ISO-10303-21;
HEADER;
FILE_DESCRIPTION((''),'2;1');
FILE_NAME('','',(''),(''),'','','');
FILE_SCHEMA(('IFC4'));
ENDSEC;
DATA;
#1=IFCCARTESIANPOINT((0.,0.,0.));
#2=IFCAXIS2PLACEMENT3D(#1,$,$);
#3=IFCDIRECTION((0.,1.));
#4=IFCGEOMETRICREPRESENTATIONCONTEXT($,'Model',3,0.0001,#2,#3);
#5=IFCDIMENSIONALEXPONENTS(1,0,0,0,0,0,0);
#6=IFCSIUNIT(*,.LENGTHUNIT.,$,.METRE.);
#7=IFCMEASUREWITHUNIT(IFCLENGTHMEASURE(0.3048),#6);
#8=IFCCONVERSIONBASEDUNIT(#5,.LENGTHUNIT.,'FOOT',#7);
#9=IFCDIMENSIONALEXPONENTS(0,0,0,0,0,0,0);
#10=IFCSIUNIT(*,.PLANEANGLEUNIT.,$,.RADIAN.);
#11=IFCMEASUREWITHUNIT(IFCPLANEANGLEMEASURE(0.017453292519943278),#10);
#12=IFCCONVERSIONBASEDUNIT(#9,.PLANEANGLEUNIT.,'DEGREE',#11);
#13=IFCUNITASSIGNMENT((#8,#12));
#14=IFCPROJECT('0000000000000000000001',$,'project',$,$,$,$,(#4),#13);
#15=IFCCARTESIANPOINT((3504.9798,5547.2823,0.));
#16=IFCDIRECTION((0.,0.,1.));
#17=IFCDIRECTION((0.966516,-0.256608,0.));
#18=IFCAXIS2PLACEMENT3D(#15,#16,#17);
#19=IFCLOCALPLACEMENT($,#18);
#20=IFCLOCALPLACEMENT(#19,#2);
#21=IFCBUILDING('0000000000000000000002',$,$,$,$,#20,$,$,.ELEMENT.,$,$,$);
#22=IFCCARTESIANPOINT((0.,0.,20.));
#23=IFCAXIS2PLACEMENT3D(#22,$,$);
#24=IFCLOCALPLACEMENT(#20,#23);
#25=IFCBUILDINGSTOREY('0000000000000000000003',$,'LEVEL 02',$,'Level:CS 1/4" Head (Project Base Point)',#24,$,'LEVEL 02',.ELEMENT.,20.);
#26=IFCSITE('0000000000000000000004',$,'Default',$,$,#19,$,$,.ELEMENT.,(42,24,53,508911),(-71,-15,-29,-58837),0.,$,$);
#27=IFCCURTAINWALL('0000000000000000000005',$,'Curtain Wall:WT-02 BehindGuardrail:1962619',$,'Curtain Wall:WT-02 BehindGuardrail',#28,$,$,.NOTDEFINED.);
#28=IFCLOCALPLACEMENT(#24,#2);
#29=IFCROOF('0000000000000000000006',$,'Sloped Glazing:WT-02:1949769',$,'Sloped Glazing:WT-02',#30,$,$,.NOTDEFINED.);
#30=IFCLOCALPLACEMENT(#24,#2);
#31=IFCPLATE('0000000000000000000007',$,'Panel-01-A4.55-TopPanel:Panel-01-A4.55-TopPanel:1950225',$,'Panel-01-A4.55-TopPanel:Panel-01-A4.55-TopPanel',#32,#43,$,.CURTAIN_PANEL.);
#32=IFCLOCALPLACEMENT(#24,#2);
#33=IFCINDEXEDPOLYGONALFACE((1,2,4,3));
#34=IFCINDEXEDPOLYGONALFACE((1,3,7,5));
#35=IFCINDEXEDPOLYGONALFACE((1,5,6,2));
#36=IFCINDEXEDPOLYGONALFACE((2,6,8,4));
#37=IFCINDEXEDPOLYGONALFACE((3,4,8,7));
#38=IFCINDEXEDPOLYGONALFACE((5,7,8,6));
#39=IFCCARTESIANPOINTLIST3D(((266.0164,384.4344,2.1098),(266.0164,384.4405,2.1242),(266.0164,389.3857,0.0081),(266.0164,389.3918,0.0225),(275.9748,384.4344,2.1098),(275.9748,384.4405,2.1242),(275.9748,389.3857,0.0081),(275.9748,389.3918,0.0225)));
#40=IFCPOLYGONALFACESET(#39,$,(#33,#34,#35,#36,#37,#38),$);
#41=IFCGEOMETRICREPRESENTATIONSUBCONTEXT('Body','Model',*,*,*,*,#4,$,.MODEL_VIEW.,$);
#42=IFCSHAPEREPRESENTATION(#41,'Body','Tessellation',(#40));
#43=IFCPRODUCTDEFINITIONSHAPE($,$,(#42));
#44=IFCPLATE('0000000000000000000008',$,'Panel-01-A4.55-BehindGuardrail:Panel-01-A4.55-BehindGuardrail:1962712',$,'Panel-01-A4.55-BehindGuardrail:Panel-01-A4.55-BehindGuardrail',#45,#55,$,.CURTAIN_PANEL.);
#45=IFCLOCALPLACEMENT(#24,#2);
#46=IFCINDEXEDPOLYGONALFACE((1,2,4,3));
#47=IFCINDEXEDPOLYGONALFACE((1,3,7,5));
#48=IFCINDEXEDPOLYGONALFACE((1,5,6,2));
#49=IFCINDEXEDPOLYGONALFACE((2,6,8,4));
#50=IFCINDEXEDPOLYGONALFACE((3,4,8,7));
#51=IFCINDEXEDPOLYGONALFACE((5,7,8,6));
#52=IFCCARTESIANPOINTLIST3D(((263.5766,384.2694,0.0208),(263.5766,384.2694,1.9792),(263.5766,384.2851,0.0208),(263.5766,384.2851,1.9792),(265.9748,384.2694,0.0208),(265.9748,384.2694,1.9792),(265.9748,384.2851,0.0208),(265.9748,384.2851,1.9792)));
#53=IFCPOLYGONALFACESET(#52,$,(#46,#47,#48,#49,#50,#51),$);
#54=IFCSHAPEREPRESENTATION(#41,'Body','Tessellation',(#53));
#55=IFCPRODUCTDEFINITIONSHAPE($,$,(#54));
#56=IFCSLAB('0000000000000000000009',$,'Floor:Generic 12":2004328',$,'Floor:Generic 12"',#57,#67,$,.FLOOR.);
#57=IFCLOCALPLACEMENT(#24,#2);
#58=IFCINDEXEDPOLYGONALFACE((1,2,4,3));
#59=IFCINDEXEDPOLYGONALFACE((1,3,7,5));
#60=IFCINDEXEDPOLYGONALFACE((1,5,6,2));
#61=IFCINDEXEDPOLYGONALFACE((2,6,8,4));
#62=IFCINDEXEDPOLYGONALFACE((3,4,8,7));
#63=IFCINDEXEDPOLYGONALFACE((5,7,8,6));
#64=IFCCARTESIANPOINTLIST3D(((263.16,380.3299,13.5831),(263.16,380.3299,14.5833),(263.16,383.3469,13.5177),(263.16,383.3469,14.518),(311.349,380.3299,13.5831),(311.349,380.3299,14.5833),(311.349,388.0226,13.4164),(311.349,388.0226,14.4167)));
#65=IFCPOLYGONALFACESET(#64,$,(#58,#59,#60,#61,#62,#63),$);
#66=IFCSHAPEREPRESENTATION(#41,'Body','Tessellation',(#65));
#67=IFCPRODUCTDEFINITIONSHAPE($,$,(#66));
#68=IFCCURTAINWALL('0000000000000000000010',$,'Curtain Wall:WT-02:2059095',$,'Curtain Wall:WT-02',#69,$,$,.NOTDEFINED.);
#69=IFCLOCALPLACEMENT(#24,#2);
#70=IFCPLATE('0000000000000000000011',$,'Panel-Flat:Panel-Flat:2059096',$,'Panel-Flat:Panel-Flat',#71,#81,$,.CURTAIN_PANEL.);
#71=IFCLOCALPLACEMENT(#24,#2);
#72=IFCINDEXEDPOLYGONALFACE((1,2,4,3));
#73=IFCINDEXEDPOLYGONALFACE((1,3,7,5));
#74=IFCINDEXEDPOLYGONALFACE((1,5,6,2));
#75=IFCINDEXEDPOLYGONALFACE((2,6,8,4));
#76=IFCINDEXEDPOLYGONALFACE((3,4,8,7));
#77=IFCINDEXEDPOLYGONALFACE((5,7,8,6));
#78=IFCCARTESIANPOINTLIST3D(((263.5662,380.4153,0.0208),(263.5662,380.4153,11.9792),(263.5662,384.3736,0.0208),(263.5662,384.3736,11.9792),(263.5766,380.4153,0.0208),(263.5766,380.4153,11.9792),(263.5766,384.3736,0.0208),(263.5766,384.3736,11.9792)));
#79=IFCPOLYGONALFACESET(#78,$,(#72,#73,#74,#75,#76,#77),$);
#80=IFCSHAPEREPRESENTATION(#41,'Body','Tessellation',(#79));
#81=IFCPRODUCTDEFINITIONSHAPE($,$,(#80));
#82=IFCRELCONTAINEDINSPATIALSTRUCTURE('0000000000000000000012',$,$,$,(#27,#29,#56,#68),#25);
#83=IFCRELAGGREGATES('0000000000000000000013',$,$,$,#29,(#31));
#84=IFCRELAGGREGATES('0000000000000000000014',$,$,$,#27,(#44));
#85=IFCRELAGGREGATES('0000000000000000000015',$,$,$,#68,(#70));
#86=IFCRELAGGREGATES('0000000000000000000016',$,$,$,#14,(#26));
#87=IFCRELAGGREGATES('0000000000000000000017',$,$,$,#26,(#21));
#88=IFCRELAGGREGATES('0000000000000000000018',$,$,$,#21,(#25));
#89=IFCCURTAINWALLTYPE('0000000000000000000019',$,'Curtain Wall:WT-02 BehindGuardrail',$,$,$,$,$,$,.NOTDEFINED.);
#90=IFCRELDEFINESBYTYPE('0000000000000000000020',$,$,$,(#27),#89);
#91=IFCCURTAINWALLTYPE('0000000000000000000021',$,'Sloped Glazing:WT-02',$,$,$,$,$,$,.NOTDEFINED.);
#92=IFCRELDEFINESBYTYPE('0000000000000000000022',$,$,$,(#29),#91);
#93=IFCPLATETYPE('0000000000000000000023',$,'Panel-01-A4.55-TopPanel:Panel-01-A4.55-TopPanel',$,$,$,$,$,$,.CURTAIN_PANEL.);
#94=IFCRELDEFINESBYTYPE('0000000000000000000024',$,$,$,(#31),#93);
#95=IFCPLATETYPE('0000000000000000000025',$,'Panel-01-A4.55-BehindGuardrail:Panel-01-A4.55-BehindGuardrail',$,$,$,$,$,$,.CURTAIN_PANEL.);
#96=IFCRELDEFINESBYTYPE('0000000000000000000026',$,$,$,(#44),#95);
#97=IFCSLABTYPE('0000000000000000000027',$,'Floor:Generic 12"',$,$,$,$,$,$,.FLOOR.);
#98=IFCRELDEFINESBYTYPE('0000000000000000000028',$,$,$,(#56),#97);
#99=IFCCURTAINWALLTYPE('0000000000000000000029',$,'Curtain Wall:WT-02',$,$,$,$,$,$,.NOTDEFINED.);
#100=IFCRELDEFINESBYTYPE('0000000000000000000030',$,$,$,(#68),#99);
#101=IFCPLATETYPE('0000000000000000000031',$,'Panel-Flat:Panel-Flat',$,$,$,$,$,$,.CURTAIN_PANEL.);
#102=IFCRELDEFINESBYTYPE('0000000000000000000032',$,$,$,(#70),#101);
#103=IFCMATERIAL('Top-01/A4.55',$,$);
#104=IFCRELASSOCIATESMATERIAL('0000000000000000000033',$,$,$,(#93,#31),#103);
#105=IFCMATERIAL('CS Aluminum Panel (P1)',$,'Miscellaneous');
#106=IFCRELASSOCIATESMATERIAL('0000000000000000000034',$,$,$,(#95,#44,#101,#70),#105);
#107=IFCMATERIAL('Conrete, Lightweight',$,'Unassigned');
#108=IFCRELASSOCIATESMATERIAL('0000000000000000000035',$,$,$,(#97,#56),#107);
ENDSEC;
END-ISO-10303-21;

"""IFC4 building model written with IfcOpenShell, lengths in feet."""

from ifc_helpers import new_model, entity, si_unit, converted_unit, direction, frame, origin, place, context, subcontext, project, spatial, polyline, indexed_curve, outline, extrude, source, transform, mapped, material, type_object, type_shapes, element, aggregate, save


model = new_model("IFC4")

# Units and contexts
model_context = context("Model", 3, precision=0.0001, world=origin(), true_north=direction((0.0, 1.0)))
body_context = subcontext(model_context, "Body", "Model", "MODEL_VIEW")
ifc_project = project(units=[converted_unit("LENGTHUNIT", "FOOT", entity("IfcLengthMeasure", 0.3048), si_unit("LENGTHUNIT", "METRE"), dimensions=[1, 0, 0, 0, 0, 0, 0]), converted_unit("PLANEANGLEUNIT", "DEGREE", entity("IfcPlaneAngleMeasure", 0.017453292519943278), si_unit("PLANEANGLEUNIT", "RADIAN"), dimensions=[0, 0, 0, 0, 0, 0, 0])], contexts=[model_context])

# Site, building, storey
site_placement = place(None, frame((3504.9798, 5547.2823, 0.0), z_axis=(0.0, 0.0, 1.0), x_axis=(0.966516, -0.256608, 0.0)))
site = spatial("IfcSite", under=ifc_project, at=site_placement, Name="Default", CompositionType="ELEMENT", RefLatitude=(42, 24, 53, 508911), RefLongitude=(-71, -15, -29, -58837), RefElevation=0.0)
building_placement = place(site_placement, origin())
building = spatial("IfcBuilding", under=site, at=building_placement, CompositionType="ELEMENT")
storey_placement = place(building_placement, frame((0.0, 0.0, 20.0)))
storey = spatial("IfcBuildingStorey", under=building, at=storey_placement, Name="LEVEL 02", ObjectType="Level:CS 1/4\" Head (Project Base Point)", LongName="LEVEL 02", CompositionType="ELEMENT", Elevation=20.0)

# Curtain wall
curtain_wall_type_1 = type_object("IfcCurtainWallType", Name="Curtain Wall:WT-02", PredefinedType="NOTDEFINED")
ifc_material_1 = material(Name="CS Aluminum Panel (P1)", Category="Miscellaneous")
curtain_wall_type_2 = type_object("IfcCurtainWallType", Name="Curtain Wall:WT-02 BehindGuardrail", PredefinedType="NOTDEFINED")
curtain_wall_1_placement = place(storey_placement, frame((0.0, 0.0, -20.0)))
curtain_wall_1 = element("IfcCurtainWall", 1, at=curtain_wall_1_placement, inside=storey, type_object=curtain_wall_type_2, Name="Curtain Wall:WT-02 BehindGuardrail:1962619", ObjectType="Curtain Wall:WT-02 BehindGuardrail", PredefinedType="NOTDEFINED")

# Roof, plate
curtain_wall_type_3 = type_object("IfcCurtainWallType", Name="Sloped Glazing:WT-02", PredefinedType="NOTDEFINED")
roof_1_placement = place(storey_placement, frame((0.0, 0.0, -20.0)))
roof_1 = element("IfcRoof", 2, at=roof_1_placement, inside=storey, type_object=curtain_wall_type_3, Name="Sloped Glazing:WT-02:1949769", ObjectType="Sloped Glazing:WT-02", PredefinedType="NOTDEFINED")
ifc_material_2 = material(Name="Top-01/A4.55")
plate_type_1 = type_object("IfcPlateType", Name="Panel-01-A4.55-TopPanel:Panel-01-A4.55-TopPanel", PredefinedType="CURTAIN_PANEL", material=ifc_material_2)
shared_shape_1 = source(origin(), body_context, "Body", "SweptSolid", [
    extrude(outline(indexed_curve([(-0.0078, -4.9792), (0.0078, -4.9792), (0.0078, 4.9792), (-0.0078, 4.9792), (-0.0078, -4.9792)], self_intersect=False)), frame((0.0, -0.0078, 0.0208), z_axis=(0.0, 0.0, 1.0), x_axis=(0.0, -1.0, 0.0)), (0.0, 0.0, 1.0), 5.3788),
])
type_shapes(plate_type_1, [shared_shape_1])
plate_1_placement = place(roof_1_placement, frame((270.9956, 389.4048, 20.0), z_axis=(0.0, -0.920505, 0.390731), x_axis=(-1.0, 0.0, 0.0)))
plate_1 = element("IfcPlate", 3, at=plate_1_placement, type_object=plate_type_1, material=ifc_material_2, Name="Panel-01-A4.55-TopPanel:Panel-01-A4.55-TopPanel:1950225", ObjectType="Panel-01-A4.55-TopPanel:Panel-01-A4.55-TopPanel", PredefinedType="CURTAIN_PANEL", context=body_context, shape_type="MappedRepresentation", body=[
    mapped(shared_shape_1, transform((0.0, 0.0, 0.0), scale=1.0)),
])
aggregate(roof_1, [plate_1])

# Plate
plate_type_2 = type_object("IfcPlateType", Name="Panel-01-A4.55-BehindGuardrail:Panel-01-A4.55-BehindGuardrail", PredefinedType="CURTAIN_PANEL", material=ifc_material_1)
shared_shape_2 = source(origin(), body_context, "Body", "SweptSolid", [
    extrude(outline(indexed_curve([(-0.0078, -1.1991), (0.0078, -1.1991), (0.0078, 1.1991), (-0.0078, 1.1991), (-0.0078, -1.1991)], self_intersect=False)), frame((0.0, -0.0078, 0.0208), z_axis=(0.0, 0.0, 1.0), x_axis=(0.0, -1.0, 0.0)), (0.0, 0.0, 1.0), 1.9583),
])
type_shapes(plate_type_2, [shared_shape_2])
plate_2_placement = place(curtain_wall_1_placement, frame((264.7757, 384.2694, 20.0), z_axis=(0.0, 0.0, 1.0), x_axis=(-1.0, 0.0, 0.0)))
plate_2 = element("IfcPlate", 4, at=plate_2_placement, type_object=plate_type_2, material=ifc_material_1, Name="Panel-01-A4.55-BehindGuardrail:Panel-01-A4.55-BehindGuardrail:1962712", ObjectType="Panel-01-A4.55-BehindGuardrail:Panel-01-A4.55-BehindGuardrail", PredefinedType="CURTAIN_PANEL", context=body_context, shape_type="MappedRepresentation", body=[
    mapped(shared_shape_2, transform((0.0, 0.0, 0.0), scale=1.0)),
])
aggregate(curtain_wall_1, [plate_2])

# Slab
ifc_material_3 = material(Name="Conrete, Lightweight", Category="Unassigned")
slab_type = type_object("IfcSlabType", Name="Floor:Generic 12\"", PredefinedType="FLOOR", material=ifc_material_3)
slab_placement = place(storey_placement, frame((263.16, 380.3299, 13.4164)))
element("IfcSlab", 5, at=slab_placement, inside=storey, type_object=slab_type, material=ifc_material_3, Name="Floor:Generic 12\":2004328", ObjectType="Floor:Generic 12\"", PredefinedType="FLOOR", context=body_context, shape_type="SweptSolid", body=[
    extrude(outline(polyline([(24.0945, 7.6945), (-24.0945, 3.0177), (-24.0945, 0.0), (24.0945, 0.0), (24.0945, 7.6945)])), frame((24.0945, 0.0, 1.1669), z_axis=(0.0, 0.021661, 0.999765), x_axis=(1.0, 0.0, 0.0)), (0.0, 0.021661, -0.999765), 1.0002),
])

# Curtain wall, plate
curtain_wall_2_placement = place(storey_placement, frame((0.0, 0.0, -20.0)))
curtain_wall_2 = element("IfcCurtainWall", 6, at=curtain_wall_2_placement, inside=storey, type_object=curtain_wall_type_1, Name="Curtain Wall:WT-02:2059095", ObjectType="Curtain Wall:WT-02", PredefinedType="NOTDEFINED")
plate_type_3 = type_object("IfcPlateType", Name="Panel-Flat:Panel-Flat", PredefinedType="CURTAIN_PANEL", material=ifc_material_1)
shared_shape_3 = source(origin(), body_context, "Body", "SweptSolid", [
    extrude(outline(indexed_curve([(-0.0052, -1.9792), (0.0052, -1.9792), (0.0052, 1.9792), (-0.0052, 1.9792), (-0.0052, -1.9792)], self_intersect=False)), frame((0.0, -0.0052, 0.0208), z_axis=(0.0, 0.0, 1.0), x_axis=(0.0, -1.0, 0.0)), (0.0, 0.0, 1.0), 11.9583),
])
type_shapes(plate_type_3, [shared_shape_3])
plate_3_placement = place(curtain_wall_2_placement, frame((263.5766, 382.3944, 20.0), z_axis=(0.0, 0.0, 1.0), x_axis=(0.0, -1.0, 0.0)))
plate_3 = element("IfcPlate", 7, at=plate_3_placement, type_object=plate_type_3, material=ifc_material_1, Name="Panel-Flat:Panel-Flat:2059096", ObjectType="Panel-Flat:Panel-Flat", PredefinedType="CURTAIN_PANEL", context=body_context, shape_type="MappedRepresentation", body=[
    mapped(shared_shape_3, transform((0.0, 0.0, 0.0), scale=1.0)),
])
aggregate(curtain_wall_2, [plate_3])

save(model, "model.ifc")
